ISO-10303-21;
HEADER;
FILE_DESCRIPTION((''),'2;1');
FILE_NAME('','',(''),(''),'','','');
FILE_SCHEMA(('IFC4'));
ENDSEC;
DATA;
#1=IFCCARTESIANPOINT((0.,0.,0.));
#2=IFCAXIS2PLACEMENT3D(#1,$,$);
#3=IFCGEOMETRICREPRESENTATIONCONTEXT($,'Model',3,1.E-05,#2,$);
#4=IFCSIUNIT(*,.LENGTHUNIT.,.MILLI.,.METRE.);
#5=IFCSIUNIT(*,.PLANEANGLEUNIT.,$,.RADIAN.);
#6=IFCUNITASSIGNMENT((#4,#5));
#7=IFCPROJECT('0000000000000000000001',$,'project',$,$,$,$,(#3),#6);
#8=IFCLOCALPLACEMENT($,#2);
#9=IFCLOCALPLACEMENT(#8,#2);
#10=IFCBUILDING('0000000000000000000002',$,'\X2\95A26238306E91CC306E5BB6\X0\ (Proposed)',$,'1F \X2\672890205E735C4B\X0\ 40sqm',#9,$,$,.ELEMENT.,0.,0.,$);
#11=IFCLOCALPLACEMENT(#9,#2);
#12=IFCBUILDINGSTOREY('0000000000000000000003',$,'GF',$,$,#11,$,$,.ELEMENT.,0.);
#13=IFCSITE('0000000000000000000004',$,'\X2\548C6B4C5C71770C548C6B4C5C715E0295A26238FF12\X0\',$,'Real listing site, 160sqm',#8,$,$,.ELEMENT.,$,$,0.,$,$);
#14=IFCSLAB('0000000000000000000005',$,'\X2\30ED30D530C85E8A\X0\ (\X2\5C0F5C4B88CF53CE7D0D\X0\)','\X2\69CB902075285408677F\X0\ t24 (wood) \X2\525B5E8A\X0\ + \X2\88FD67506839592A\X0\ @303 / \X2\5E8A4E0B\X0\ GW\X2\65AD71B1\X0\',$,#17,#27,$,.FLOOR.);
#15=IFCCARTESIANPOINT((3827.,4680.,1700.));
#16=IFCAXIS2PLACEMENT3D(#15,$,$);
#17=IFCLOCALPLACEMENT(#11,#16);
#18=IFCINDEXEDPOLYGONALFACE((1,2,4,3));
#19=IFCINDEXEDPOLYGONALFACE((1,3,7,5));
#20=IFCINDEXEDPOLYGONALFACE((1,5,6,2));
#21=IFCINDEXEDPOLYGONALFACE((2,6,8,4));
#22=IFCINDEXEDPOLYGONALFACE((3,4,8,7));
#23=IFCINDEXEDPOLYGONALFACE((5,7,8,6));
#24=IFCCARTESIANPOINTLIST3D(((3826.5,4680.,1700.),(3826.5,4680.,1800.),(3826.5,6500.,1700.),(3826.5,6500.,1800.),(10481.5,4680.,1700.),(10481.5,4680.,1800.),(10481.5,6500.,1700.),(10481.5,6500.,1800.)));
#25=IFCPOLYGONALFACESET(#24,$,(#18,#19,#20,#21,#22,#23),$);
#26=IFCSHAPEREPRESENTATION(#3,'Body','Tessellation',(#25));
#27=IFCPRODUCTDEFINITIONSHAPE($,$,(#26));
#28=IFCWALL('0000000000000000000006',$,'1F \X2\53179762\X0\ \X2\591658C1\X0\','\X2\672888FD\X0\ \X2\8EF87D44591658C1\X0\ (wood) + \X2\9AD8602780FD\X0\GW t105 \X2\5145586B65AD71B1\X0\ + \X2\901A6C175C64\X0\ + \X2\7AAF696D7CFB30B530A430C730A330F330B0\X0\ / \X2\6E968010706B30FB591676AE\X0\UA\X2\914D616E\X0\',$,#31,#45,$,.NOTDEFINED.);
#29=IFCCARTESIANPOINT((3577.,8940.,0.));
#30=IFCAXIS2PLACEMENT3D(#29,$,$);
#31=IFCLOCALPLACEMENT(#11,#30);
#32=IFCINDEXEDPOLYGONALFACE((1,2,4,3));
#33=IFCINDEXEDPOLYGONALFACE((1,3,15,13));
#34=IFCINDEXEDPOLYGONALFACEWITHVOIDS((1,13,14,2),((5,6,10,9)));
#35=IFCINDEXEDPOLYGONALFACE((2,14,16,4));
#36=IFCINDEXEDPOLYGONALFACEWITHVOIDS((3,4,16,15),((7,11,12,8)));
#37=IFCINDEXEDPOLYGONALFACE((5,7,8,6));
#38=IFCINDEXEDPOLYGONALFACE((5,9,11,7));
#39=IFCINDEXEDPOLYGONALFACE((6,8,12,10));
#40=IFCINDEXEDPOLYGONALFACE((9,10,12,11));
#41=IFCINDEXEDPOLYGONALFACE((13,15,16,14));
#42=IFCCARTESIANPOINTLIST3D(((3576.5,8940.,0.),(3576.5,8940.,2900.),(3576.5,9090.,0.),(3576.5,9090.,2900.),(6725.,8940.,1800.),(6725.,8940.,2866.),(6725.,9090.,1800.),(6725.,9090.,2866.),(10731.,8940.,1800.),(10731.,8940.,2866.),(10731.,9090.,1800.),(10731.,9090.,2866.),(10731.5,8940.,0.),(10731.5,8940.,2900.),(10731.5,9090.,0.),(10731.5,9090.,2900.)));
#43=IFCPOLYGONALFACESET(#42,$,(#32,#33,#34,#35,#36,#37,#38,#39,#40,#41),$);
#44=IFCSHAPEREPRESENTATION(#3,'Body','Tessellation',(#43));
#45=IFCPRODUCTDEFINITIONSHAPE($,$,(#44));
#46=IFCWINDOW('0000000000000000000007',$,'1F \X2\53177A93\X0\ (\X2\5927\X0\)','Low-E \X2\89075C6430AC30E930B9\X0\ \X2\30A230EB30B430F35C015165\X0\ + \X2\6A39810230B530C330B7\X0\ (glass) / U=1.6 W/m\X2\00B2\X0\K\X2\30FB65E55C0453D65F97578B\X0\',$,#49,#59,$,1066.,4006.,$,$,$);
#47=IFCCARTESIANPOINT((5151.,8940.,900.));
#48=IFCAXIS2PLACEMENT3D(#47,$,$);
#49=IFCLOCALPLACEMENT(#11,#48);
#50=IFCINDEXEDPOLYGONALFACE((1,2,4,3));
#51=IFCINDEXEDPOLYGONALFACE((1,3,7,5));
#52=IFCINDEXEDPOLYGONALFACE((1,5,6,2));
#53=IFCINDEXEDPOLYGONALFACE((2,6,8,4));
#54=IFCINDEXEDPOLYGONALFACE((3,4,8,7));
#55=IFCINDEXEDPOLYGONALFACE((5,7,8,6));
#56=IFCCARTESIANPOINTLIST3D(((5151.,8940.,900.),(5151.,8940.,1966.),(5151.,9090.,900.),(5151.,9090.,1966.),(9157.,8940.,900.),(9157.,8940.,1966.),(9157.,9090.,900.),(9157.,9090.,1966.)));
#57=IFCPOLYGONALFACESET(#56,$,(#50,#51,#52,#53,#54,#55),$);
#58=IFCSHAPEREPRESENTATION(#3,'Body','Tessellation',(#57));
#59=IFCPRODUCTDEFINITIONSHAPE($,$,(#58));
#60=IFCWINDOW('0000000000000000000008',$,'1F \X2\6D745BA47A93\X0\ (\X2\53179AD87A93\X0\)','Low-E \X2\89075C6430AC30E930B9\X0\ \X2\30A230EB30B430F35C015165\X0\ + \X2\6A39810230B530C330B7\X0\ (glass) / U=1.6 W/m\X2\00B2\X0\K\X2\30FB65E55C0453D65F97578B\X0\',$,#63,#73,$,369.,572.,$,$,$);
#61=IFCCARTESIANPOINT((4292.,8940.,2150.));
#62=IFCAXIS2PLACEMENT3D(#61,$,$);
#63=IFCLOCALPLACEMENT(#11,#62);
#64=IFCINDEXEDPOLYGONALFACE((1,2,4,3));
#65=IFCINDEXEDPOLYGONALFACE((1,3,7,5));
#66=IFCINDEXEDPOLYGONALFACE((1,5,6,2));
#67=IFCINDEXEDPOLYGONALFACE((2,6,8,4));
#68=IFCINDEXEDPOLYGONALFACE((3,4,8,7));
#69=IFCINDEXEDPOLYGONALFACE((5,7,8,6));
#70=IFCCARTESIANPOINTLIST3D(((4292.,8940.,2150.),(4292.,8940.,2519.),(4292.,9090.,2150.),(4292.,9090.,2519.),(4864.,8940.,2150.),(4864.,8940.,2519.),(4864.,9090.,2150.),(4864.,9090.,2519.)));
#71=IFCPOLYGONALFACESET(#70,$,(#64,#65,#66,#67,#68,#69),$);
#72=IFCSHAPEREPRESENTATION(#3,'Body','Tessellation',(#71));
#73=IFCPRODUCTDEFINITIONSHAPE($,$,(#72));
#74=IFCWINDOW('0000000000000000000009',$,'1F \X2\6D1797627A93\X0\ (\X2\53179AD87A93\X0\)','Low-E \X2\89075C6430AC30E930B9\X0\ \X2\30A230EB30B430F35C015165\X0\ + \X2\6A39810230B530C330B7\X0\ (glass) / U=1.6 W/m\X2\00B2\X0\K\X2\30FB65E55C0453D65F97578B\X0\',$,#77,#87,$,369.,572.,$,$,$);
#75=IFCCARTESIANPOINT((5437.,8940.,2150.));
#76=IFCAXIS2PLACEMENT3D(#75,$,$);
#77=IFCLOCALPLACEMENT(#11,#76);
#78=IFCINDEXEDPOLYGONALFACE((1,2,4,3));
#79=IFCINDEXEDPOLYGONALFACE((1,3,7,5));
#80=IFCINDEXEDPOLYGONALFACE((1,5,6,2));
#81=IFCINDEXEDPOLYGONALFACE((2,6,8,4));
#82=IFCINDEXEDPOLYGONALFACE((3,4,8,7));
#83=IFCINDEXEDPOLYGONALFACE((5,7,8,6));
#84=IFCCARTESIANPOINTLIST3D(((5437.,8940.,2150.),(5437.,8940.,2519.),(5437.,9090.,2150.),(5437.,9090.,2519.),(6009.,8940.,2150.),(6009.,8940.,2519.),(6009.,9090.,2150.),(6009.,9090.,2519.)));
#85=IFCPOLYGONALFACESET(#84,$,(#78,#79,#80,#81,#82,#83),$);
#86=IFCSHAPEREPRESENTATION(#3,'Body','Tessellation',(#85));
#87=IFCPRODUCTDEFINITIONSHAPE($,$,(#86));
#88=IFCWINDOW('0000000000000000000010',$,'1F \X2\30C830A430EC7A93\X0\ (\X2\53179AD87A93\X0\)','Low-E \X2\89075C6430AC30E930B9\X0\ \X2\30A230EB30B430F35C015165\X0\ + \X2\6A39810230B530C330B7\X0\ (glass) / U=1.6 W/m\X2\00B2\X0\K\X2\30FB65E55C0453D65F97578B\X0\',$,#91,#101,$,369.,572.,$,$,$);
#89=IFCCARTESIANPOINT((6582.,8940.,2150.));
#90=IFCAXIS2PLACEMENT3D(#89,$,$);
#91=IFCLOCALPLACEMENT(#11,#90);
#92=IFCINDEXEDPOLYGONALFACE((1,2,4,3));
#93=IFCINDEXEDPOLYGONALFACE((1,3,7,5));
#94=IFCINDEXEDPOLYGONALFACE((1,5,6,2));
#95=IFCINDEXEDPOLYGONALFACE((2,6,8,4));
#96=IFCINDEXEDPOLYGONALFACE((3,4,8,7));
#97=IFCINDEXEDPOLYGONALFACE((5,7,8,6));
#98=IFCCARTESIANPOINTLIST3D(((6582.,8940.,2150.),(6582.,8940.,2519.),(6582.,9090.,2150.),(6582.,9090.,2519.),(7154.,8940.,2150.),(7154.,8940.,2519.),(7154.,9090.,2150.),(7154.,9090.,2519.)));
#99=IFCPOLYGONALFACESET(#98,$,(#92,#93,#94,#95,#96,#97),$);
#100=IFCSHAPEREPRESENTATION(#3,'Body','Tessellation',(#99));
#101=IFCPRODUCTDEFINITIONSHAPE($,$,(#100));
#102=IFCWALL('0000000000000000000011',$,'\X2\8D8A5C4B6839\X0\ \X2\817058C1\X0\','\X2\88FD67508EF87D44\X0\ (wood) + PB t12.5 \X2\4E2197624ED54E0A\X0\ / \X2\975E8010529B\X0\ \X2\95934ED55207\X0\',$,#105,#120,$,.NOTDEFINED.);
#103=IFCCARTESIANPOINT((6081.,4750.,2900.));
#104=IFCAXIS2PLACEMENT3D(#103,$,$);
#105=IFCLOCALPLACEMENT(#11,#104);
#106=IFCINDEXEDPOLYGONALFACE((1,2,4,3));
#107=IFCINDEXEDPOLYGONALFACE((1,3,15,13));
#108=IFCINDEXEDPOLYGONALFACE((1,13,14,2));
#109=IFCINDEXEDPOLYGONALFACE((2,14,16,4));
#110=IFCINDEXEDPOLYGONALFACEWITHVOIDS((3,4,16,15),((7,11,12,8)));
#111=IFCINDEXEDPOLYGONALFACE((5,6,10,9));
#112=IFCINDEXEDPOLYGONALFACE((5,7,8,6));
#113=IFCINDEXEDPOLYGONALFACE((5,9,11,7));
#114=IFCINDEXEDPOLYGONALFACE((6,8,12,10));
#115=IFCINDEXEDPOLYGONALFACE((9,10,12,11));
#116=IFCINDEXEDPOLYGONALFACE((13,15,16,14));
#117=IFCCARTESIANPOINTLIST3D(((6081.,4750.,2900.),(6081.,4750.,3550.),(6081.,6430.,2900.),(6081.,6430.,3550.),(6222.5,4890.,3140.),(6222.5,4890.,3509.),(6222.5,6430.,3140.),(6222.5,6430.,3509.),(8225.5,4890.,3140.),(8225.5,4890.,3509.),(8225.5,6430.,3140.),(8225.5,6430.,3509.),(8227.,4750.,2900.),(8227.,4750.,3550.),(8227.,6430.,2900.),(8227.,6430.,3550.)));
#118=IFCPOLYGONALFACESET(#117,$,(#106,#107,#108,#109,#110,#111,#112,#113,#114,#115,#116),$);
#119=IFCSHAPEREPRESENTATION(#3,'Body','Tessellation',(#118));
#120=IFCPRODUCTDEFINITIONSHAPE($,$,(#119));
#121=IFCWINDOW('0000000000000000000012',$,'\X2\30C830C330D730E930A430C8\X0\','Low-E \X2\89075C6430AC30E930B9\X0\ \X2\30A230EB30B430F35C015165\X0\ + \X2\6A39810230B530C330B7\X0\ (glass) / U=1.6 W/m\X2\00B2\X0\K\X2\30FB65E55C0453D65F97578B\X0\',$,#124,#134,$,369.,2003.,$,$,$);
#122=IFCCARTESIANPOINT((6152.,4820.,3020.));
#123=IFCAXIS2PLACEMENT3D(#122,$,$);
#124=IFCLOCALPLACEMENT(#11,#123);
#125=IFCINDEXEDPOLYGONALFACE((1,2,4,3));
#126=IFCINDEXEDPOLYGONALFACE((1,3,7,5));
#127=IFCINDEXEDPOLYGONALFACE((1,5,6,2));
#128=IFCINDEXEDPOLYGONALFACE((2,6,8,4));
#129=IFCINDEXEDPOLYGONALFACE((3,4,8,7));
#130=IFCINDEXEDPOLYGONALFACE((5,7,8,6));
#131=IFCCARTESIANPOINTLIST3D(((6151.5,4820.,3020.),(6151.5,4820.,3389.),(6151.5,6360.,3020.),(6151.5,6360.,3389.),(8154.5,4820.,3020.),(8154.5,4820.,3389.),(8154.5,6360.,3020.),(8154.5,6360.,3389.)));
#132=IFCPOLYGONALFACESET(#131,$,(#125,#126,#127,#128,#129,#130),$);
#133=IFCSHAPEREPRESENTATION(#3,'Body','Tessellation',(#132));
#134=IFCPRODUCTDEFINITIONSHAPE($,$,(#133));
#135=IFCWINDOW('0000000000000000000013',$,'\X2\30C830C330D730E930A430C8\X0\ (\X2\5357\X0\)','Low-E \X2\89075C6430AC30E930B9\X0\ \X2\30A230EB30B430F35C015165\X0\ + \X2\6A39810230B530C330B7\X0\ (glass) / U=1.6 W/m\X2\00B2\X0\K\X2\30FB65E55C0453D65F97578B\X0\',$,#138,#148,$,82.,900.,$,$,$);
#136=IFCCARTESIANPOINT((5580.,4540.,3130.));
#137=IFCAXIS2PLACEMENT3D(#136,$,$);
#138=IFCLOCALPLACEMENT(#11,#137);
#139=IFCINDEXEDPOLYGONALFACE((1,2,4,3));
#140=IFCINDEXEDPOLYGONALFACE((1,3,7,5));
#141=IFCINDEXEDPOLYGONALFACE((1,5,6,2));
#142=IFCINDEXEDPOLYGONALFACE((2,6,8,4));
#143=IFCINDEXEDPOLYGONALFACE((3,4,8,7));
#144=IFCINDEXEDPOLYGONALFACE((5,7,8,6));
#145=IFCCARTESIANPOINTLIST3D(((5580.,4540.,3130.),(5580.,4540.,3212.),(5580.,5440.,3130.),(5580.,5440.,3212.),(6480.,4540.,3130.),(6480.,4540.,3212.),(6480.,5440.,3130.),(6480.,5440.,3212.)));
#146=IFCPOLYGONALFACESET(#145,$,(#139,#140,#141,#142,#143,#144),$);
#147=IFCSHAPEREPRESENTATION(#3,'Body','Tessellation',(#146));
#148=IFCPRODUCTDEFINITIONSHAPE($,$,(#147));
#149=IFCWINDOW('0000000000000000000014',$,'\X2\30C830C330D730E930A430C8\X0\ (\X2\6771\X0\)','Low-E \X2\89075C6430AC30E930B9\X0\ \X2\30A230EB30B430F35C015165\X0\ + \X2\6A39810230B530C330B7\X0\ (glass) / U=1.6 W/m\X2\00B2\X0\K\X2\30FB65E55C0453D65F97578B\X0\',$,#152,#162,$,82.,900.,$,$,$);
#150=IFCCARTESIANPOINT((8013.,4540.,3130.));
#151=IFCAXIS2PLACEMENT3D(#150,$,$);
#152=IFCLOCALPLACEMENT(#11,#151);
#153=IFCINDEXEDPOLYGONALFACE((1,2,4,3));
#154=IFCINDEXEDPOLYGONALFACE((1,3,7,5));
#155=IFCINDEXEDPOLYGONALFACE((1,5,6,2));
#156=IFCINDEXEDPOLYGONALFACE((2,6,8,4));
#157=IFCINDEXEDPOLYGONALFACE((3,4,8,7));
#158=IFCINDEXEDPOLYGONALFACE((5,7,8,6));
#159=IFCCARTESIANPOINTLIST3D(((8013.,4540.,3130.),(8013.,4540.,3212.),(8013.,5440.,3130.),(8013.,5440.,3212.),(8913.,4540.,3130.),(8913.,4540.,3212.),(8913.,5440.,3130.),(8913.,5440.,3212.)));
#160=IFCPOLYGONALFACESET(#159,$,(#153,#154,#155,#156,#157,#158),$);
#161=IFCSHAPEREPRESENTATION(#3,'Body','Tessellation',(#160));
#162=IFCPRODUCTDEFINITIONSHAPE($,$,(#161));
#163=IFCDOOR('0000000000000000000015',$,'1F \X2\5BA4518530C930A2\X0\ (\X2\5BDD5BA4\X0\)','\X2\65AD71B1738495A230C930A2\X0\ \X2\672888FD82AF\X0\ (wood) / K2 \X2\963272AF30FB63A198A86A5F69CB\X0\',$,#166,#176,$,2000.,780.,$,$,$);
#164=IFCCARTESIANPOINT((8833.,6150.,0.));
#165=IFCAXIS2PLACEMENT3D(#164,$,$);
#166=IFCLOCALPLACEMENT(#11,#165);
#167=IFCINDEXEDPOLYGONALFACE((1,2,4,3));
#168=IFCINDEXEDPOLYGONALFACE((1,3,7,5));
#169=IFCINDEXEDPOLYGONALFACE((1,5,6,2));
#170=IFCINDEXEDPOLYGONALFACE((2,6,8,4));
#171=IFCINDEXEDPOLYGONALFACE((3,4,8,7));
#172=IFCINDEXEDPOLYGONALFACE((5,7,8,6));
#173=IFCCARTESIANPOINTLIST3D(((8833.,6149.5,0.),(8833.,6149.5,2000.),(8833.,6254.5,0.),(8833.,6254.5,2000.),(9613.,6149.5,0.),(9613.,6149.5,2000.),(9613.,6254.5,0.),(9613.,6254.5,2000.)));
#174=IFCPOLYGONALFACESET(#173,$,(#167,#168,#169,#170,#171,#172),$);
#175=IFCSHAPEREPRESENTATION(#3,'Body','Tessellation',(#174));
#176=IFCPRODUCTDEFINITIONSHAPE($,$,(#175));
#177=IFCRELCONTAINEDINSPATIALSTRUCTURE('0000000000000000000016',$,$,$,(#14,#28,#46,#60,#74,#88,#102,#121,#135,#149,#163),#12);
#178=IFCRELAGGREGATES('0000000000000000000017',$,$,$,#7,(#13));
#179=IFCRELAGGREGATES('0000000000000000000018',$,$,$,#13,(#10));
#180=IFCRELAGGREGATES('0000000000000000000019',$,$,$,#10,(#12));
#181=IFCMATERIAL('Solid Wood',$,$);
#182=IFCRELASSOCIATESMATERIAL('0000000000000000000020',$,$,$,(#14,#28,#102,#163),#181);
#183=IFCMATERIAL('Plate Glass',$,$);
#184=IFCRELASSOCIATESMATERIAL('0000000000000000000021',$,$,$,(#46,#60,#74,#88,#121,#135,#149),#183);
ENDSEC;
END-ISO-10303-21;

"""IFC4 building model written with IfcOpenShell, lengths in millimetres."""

from ifc_helpers import new_model, si_unit, frame, frame_2d, origin, place, context, project, spatial, rectangle, extrude, material, element, fill, save


model = new_model("IFC4")

# Units and contexts
model_context = context("Model", 3, precision=1e-05, world=origin())
ifc_project = project(units=[si_unit("LENGTHUNIT", "METRE", prefix="MILLI"), si_unit("PLANEANGLEUNIT", "RADIAN")], contexts=[model_context])

# Site, building, storey
site_placement = place(None, origin())
site = spatial("IfcSite", under=ifc_project, at=site_placement, Name="和歌山県和歌山市関戸２", ObjectType="Real listing site, 160sqm", CompositionType="ELEMENT", RefElevation=0.0)
building_placement = place(site_placement, origin())
building = spatial("IfcBuilding", under=site, at=building_placement, Name="関戸の里の家 (Proposed)", ObjectType="1F 木造平屋 40sqm", CompositionType="ELEMENT", ElevationOfRefHeight=0.0, ElevationOfTerrain=0.0)
storey_placement = place(building_placement, origin())
storey = spatial("IfcBuildingStorey", under=building, at=storey_placement, Name="GF", CompositionType="ELEMENT", Elevation=0.0)

# Slab
ifc_material_1 = material(Name="Solid Wood")
slab_placement = place(storey_placement, frame((3827.0, 4680.0, 1700.0)))
element("IfcSlab", 1, at=slab_placement, inside=storey, material=ifc_material_1, Name="ロフト床 (小屋裏収納)", Description="構造用合板 t24 (wood) 剛床 + 製材根太 @303 / 床下 GW断熱", PredefinedType="FLOOR", context=model_context, shape_type="SweptSolid", body=[
    extrude(rectangle(XDim=6655.0, YDim=1820.0, at=frame_2d((3327.0, 910.0))), frame((3827.0, 4680.0, 1700.0)), (0.0, 0.0, 1.0), 100.0),
])

# Wall, openings, windows
wall_1_placement = place(storey_placement, frame((3577.0, 8940.0, 0.0)))
wall_1 = element("IfcWall", 2, at=wall_1_placement, inside=storey, material=ifc_material_1, Name="1F 北面 外壁", Description="木製 軸組外壁 (wood) + 高性能GW t105 充填断熱 + 通気層 + 窯業系サイディング / 準耐火・外皮UA配慮", PredefinedType="NOTDEFINED", context=model_context, shape_type="SweptSolid", body=[
    extrude(rectangle(XDim=7155.0, YDim=150.0, at=frame_2d((3577.0, 75.0))), frame((3577.0, 8940.0, 0.0)), (0.0, 0.0, 1.0), 2900.0),
])
opening_1_placement = place(storey_placement, frame((5151.0, 8940.0, 900.0)))
opening_1 = element("IfcOpeningElement", 3, at=opening_1_placement, cuts=wall_1, PredefinedType="NOTDEFINED", context=model_context, shape_type="SweptSolid", body=[
    extrude(rectangle(XDim=4006.0, YDim=150.0, at=frame_2d((2003.0, 75.0))), frame((5151.0, 8940.0, 900.0)), (0.0, 0.0, 1.0), 1066.0),
])
opening_2_placement = place(storey_placement, frame((4292.0, 8940.0, 2150.0)))
opening_2 = element("IfcOpeningElement", 4, at=opening_2_placement, cuts=wall_1, PredefinedType="NOTDEFINED", context=model_context, shape_type="SweptSolid", body=[
    extrude(rectangle(XDim=572.0, YDim=150.0, at=frame_2d((286.0, 75.0))), frame((4292.0, 8940.0, 2150.0)), (0.0, 0.0, 1.0), 369.0),
])
opening_3_placement = place(storey_placement, frame((5437.0, 8940.0, 2150.0)))
opening_3 = element("IfcOpeningElement", 5, at=opening_3_placement, cuts=wall_1, PredefinedType="NOTDEFINED", context=model_context, shape_type="SweptSolid", body=[
    extrude(rectangle(XDim=572.0, YDim=150.0, at=frame_2d((286.0, 75.0))), frame((5437.0, 8940.0, 2150.0)), (0.0, 0.0, 1.0), 369.0),
])
opening_4_placement = place(storey_placement, frame((6582.0, 8940.0, 2150.0)))
opening_4 = element("IfcOpeningElement", 6, at=opening_4_placement, cuts=wall_1, PredefinedType="NOTDEFINED", context=model_context, shape_type="SweptSolid", body=[
    extrude(rectangle(XDim=572.0, YDim=150.0, at=frame_2d((286.0, 75.0))), frame((6582.0, 8940.0, 2150.0)), (0.0, 0.0, 1.0), 369.0),
])
ifc_material_2 = material(Name="Plate Glass")
window_1_placement = place(storey_placement, frame((5151.0, 8940.0, 900.0)))
window_1 = element("IfcWindow", 7, at=window_1_placement, inside=storey, material=ifc_material_2, Name="1F 北窓 (大)", Description="Low-E 複層ガラス アルゴン封入 + 樹脂サッシ (glass) / U=1.6 W/m²K・日射取得型", OverallHeight=1066.0, OverallWidth=4006.0, context=model_context, shape_type="SweptSolid", body=[
    extrude(rectangle(XDim=4006.0, YDim=150.0, at=frame_2d((2003.0, 75.0))), frame((5151.0, 8940.0, 900.0)), (0.0, 0.0, 1.0), 1066.0),
])
fill(opening_1, window_1)
window_2_placement = place(storey_placement, frame((4292.0, 8940.0, 2150.0)))
window_2 = element("IfcWindow", 8, at=window_2_placement, inside=storey, material=ifc_material_2, Name="1F 浴室窓 (北高窓)", Description="Low-E 複層ガラス アルゴン封入 + 樹脂サッシ (glass) / U=1.6 W/m²K・日射取得型", OverallHeight=369.0, OverallWidth=572.0, context=model_context, shape_type="SweptSolid", body=[
    extrude(rectangle(XDim=572.0, YDim=150.0, at=frame_2d((286.0, 75.0))), frame((4292.0, 8940.0, 2150.0)), (0.0, 0.0, 1.0), 369.0),
])
fill(opening_2, window_2)
window_3_placement = place(storey_placement, frame((5437.0, 8940.0, 2150.0)))
window_3 = element("IfcWindow", 9, at=window_3_placement, inside=storey, material=ifc_material_2, Name="1F 洗面窓 (北高窓)", Description="Low-E 複層ガラス アルゴン封入 + 樹脂サッシ (glass) / U=1.6 W/m²K・日射取得型", OverallHeight=369.0, OverallWidth=572.0, context=model_context, shape_type="SweptSolid", body=[
    extrude(rectangle(XDim=572.0, YDim=150.0, at=frame_2d((286.0, 75.0))), frame((5437.0, 8940.0, 2150.0)), (0.0, 0.0, 1.0), 369.0),
])
fill(opening_3, window_3)
window_4_placement = place(storey_placement, frame((6582.0, 8940.0, 2150.0)))
window_4 = element("IfcWindow", 10, at=window_4_placement, inside=storey, material=ifc_material_2, Name="1F トイレ窓 (北高窓)", Description="Low-E 複層ガラス アルゴン封入 + 樹脂サッシ (glass) / U=1.6 W/m²K・日射取得型", OverallHeight=369.0, OverallWidth=572.0, context=model_context, shape_type="SweptSolid", body=[
    extrude(rectangle(XDim=572.0, YDim=150.0, at=frame_2d((286.0, 75.0))), frame((6582.0, 8940.0, 2150.0)), (0.0, 0.0, 1.0), 369.0),
])
fill(opening_4, window_4)

# Wall, openings, windows
wall_2_placement = place(storey_placement, frame((6081.0, 4750.0, 2900.0)))
wall_2 = element("IfcWall", 11, at=wall_2_placement, inside=storey, material=ifc_material_1, Name="越屋根 腰壁", Description="製材軸組 (wood) + PB t12.5 両面仕上 / 非耐力 間仕切", PredefinedType="NOTDEFINED", context=model_context, shape_type="SweptSolid", body=[
    extrude(rectangle(XDim=2146.0, YDim=1680.0, at=frame_2d((1073.0, 840.0))), frame((6081.0, 4750.0, 2900.0)), (0.0, 0.0, 1.0), 650.0),
])
opening_5_placement = place(storey_placement, frame((6152.0, 4820.0, 3020.0)))
opening_5 = element("IfcOpeningElement", 12, at=opening_5_placement, cuts=wall_2, PredefinedType="NOTDEFINED", context=model_context, shape_type="SweptSolid", body=[
    extrude(rectangle(XDim=2003.0, YDim=1540.0, at=frame_2d((1001.0, 770.0))), frame((6152.0, 4820.0, 3020.0)), (0.0, 0.0, 1.0), 369.0),
])
opening_6_placement = place(storey_placement, frame((5580.0, 4540.0, 3130.0)))
opening_6 = element("IfcOpeningElement", 13, at=opening_6_placement, cuts=wall_2, PredefinedType="NOTDEFINED", context=model_context, shape_type="SweptSolid", body=[
    extrude(rectangle(XDim=900.0, YDim=900.0, at=frame_2d((450.0, 450.0))), frame((5580.0, 4540.0, 3130.0)), (0.0, 0.0, 1.0), 82.0),
])
opening_7_placement = place(storey_placement, frame((8013.0, 4540.0, 3130.0)))
opening_7 = element("IfcOpeningElement", 14, at=opening_7_placement, cuts=wall_2, PredefinedType="NOTDEFINED", context=model_context, shape_type="SweptSolid", body=[
    extrude(rectangle(XDim=900.0, YDim=900.0, at=frame_2d((450.0, 450.0))), frame((8013.0, 4540.0, 3130.0)), (0.0, 0.0, 1.0), 82.0),
])
window_5_placement = place(storey_placement, frame((6152.0, 4820.0, 3020.0)))
window_5 = element("IfcWindow", 15, at=window_5_placement, inside=storey, material=ifc_material_2, Name="トップライト", Description="Low-E 複層ガラス アルゴン封入 + 樹脂サッシ (glass) / U=1.6 W/m²K・日射取得型", OverallHeight=369.0, OverallWidth=2003.0, context=model_context, shape_type="SweptSolid", body=[
    extrude(rectangle(XDim=2003.0, YDim=1540.0, at=frame_2d((1001.0, 770.0))), frame((6152.0, 4820.0, 3020.0)), (0.0, 0.0, 1.0), 369.0),
])
fill(opening_5, window_5)
window_6_placement = place(storey_placement, frame((5580.0, 4540.0, 3130.0)))
window_6 = element("IfcWindow", 16, at=window_6_placement, inside=storey, material=ifc_material_2, Name="トップライト (南)", Description="Low-E 複層ガラス アルゴン封入 + 樹脂サッシ (glass) / U=1.6 W/m²K・日射取得型", OverallHeight=82.0, OverallWidth=900.0, context=model_context, shape_type="SweptSolid", body=[
    extrude(rectangle(XDim=900.0, YDim=900.0, at=frame_2d((450.0, 450.0))), frame((5580.0, 4540.0, 3130.0)), (0.0, 0.0, 1.0), 82.0),
])
fill(opening_6, window_6)
window_7_placement = place(storey_placement, frame((8013.0, 4540.0, 3130.0)))
window_7 = element("IfcWindow", 17, at=window_7_placement, inside=storey, material=ifc_material_2, Name="トップライト (東)", Description="Low-E 複層ガラス アルゴン封入 + 樹脂サッシ (glass) / U=1.6 W/m²K・日射取得型", OverallHeight=82.0, OverallWidth=900.0, context=model_context, shape_type="SweptSolid", body=[
    extrude(rectangle(XDim=900.0, YDim=900.0, at=frame_2d((450.0, 450.0))), frame((8013.0, 4540.0, 3130.0)), (0.0, 0.0, 1.0), 82.0),
])
fill(opening_7, window_7)

# Door
door_1_placement = place(storey_placement, frame((8833.0, 6150.0, 0.0)))
element("IfcDoor", 18, at=door_1_placement, inside=storey, material=ifc_material_1, Name="1F 室内ドア (寝室)", Description="断熱玄関ドア 木製芯 (wood) / K2 防犯・採風機構", OverallHeight=2000.0, OverallWidth=780.0, context=model_context, shape_type="SweptSolid", body=[
    extrude(rectangle(XDim=780.0, YDim=105.0, at=frame_2d((390.0, 52.0))), frame((8833.0, 6150.0, 0.0)), (0.0, 0.0, 1.0), 2000.0),
])

save(model, "model.ifc")
